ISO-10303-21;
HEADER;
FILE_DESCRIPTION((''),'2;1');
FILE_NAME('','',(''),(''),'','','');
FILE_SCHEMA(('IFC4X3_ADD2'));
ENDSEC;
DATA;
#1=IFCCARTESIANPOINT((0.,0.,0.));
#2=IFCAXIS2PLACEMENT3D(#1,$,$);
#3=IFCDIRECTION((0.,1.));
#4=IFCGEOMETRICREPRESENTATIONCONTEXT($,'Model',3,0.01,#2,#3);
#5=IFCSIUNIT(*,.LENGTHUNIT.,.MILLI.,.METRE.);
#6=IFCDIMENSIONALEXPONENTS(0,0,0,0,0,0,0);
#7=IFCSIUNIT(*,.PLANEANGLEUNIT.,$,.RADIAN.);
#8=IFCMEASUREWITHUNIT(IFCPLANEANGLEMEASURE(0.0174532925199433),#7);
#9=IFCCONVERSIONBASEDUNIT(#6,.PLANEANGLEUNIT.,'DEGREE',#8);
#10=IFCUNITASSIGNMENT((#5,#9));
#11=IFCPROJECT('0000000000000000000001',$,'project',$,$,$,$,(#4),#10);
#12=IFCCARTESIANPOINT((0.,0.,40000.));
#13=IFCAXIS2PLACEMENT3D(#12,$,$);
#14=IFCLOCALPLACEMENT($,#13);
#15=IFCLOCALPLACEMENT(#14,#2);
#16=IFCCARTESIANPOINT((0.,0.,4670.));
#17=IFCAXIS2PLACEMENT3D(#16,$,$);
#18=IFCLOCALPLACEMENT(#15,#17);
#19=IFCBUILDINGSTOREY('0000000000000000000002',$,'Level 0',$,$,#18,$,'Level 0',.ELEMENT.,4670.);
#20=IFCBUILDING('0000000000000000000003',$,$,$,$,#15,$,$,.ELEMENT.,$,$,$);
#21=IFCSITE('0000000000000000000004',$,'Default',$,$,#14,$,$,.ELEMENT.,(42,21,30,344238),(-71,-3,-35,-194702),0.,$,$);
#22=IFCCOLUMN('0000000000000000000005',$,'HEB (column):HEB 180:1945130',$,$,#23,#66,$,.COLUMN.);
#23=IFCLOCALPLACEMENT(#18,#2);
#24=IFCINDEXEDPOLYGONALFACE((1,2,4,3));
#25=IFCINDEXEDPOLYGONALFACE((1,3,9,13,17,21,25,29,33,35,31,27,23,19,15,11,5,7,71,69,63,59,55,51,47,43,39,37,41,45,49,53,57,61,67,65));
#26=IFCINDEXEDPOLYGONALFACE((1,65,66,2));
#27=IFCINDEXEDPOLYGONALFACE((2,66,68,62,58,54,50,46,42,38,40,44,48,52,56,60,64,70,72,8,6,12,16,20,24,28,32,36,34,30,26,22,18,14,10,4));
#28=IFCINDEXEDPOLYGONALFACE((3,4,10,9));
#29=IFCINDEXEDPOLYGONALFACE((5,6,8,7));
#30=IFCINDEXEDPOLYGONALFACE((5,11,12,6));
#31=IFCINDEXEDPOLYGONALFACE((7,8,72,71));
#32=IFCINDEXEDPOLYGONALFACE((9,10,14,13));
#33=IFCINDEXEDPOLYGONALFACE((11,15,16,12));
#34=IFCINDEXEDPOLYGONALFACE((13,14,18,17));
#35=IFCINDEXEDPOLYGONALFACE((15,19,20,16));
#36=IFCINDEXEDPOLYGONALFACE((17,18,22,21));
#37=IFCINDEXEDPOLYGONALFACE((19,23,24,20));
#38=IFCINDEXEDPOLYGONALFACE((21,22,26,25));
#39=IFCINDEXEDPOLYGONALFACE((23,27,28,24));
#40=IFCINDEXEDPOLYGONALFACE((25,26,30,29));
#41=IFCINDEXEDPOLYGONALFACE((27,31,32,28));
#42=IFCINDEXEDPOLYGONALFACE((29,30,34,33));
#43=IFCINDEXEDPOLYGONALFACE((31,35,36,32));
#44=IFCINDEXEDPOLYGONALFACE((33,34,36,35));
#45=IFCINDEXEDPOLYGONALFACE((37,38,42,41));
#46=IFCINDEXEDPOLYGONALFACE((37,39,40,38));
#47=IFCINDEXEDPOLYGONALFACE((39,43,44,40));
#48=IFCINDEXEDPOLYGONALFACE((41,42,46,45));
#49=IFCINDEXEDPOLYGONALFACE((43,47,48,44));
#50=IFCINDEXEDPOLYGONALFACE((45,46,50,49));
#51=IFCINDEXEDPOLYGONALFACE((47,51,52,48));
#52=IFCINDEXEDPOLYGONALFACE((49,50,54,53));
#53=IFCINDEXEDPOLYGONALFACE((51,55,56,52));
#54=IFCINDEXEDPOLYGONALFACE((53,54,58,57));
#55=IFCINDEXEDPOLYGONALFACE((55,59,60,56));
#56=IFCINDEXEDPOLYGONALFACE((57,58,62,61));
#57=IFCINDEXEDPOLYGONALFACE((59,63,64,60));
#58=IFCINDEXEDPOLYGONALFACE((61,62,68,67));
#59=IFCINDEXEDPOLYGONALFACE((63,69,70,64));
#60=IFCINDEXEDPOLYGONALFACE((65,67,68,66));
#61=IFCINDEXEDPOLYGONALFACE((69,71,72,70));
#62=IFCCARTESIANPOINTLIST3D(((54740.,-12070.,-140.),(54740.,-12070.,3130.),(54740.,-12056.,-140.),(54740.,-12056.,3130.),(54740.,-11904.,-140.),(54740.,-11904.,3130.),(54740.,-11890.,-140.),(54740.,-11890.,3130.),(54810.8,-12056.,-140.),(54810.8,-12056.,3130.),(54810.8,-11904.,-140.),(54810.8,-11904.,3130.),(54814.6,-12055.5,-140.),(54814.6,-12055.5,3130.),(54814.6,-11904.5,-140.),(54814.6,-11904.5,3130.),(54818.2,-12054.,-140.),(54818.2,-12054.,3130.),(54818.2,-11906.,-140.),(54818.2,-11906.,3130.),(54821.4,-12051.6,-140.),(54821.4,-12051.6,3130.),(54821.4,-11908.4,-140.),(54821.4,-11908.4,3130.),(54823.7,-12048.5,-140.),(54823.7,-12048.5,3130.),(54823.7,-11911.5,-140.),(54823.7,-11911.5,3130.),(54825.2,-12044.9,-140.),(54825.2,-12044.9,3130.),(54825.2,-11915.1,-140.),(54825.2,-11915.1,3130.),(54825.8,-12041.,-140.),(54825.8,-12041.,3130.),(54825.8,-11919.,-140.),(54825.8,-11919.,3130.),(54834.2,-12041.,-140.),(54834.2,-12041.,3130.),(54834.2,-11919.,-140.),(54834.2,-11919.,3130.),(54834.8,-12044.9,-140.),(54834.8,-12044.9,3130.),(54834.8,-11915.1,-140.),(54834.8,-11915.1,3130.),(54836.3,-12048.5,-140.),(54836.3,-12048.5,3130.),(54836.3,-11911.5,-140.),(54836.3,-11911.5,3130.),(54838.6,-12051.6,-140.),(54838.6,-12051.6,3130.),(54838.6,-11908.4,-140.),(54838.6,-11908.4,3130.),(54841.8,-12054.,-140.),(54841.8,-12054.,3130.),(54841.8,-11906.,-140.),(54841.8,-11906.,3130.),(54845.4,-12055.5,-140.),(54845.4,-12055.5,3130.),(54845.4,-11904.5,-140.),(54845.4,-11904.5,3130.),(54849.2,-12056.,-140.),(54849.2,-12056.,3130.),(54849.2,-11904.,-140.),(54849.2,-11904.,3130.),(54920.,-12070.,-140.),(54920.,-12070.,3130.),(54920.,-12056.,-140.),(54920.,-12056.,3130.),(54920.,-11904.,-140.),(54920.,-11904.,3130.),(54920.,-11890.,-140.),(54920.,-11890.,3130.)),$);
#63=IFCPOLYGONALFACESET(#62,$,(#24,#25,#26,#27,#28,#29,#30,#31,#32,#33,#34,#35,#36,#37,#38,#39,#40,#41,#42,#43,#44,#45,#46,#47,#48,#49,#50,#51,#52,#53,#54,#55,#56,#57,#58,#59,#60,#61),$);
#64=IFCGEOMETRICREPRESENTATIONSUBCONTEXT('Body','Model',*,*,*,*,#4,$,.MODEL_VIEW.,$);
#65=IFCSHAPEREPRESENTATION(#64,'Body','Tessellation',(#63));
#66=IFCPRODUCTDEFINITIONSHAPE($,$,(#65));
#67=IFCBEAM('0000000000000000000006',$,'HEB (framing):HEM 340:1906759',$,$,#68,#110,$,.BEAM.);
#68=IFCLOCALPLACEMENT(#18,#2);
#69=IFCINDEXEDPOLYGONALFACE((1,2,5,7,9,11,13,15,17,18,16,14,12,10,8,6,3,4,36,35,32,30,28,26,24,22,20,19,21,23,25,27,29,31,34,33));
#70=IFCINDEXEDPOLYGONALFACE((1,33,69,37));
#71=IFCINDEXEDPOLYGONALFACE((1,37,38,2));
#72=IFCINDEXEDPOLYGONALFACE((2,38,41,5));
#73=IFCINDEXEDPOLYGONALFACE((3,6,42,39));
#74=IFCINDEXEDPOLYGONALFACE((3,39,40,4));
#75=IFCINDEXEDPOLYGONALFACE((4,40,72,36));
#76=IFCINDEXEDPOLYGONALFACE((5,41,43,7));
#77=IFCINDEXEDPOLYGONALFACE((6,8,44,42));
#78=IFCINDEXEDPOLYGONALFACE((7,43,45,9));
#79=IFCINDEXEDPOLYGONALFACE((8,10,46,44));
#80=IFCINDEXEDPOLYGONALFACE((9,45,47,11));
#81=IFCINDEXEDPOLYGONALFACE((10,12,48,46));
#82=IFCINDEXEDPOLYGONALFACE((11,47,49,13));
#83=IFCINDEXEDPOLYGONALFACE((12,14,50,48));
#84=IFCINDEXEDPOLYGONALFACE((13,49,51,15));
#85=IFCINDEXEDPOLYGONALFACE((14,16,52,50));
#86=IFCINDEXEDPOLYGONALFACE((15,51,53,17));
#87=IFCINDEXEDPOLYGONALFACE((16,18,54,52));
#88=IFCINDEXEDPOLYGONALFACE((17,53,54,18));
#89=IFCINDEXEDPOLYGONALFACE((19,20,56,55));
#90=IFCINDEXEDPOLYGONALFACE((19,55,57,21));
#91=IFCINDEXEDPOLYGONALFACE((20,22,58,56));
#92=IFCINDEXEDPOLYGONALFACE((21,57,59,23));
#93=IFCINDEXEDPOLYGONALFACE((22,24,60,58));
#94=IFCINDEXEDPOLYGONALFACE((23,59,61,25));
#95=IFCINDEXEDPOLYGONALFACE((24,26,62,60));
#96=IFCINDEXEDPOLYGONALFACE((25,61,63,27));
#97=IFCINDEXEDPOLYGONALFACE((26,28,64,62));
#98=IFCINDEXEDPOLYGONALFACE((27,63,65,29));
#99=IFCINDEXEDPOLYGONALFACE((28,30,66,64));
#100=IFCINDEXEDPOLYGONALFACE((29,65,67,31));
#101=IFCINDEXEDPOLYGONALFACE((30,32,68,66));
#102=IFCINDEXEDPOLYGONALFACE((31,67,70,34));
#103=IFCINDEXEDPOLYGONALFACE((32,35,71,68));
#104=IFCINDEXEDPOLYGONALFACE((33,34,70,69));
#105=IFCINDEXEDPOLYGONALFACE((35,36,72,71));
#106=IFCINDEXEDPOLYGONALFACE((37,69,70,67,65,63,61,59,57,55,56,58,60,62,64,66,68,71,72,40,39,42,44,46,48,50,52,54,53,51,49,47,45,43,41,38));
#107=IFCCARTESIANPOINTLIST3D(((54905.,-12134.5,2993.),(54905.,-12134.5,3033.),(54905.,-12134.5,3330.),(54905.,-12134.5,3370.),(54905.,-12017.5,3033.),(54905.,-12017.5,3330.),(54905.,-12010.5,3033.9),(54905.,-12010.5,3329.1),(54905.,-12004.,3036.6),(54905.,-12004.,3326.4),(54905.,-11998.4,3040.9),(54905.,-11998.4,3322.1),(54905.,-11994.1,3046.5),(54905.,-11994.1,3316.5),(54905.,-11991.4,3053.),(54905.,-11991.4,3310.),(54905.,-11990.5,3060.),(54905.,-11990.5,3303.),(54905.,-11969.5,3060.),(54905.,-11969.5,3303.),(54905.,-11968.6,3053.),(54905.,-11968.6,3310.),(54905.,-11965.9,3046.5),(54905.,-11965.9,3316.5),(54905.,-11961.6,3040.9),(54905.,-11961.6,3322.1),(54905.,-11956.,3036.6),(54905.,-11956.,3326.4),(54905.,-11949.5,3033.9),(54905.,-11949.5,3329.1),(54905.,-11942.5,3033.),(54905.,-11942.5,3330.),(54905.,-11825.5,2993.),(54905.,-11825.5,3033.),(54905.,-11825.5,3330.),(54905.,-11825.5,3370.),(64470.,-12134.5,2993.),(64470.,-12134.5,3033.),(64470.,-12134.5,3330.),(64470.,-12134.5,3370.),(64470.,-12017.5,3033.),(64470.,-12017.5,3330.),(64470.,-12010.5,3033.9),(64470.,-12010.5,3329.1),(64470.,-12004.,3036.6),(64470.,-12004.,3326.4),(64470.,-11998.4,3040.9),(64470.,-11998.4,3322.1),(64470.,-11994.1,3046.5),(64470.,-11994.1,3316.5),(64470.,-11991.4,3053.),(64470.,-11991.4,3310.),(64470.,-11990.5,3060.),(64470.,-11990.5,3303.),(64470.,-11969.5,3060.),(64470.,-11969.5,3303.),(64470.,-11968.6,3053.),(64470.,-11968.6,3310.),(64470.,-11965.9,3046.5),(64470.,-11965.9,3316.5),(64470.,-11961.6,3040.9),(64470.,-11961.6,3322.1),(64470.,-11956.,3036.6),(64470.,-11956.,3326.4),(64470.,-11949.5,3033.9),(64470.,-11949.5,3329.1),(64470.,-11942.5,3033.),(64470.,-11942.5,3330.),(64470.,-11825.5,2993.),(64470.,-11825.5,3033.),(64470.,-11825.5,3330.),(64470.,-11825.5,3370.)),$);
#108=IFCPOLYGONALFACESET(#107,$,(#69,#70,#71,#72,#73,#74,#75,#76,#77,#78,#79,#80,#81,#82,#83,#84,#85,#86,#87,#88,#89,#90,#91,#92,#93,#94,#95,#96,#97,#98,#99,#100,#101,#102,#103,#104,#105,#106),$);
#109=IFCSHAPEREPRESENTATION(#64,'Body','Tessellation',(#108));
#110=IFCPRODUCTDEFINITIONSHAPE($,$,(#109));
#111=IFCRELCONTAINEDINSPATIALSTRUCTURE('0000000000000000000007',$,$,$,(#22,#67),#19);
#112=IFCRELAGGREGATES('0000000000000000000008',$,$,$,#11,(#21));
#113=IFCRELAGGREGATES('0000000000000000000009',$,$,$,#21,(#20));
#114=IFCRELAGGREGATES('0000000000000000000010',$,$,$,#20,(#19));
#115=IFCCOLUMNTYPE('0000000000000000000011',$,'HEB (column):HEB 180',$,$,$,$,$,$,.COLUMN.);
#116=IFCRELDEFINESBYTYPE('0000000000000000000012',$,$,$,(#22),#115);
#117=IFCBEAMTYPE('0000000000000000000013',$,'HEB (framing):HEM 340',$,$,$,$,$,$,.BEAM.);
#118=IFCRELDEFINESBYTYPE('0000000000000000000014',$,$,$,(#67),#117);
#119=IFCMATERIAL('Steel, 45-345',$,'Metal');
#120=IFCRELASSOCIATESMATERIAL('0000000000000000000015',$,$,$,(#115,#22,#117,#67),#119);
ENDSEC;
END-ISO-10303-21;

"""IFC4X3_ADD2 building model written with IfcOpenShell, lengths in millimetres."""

from ifc_helpers import new_model, entity, si_unit, converted_unit, direction, frame, frame_2d, origin, origin_2d_with_axis, place, context, subcontext, project, spatial, polyline, circle_curve, parameter, trimmed, segment, composite_curve, i_section, outline, extrude, source, transform, mapped, material, material_profile, profile_set, profile_usage, type_object, type_shapes, element, save


model = new_model("IFC4X3_ADD2")

# Units and contexts
model_context = context("Model", 3, precision=0.01, world=origin(), true_north=direction((0.0, 1.0)))
body_context = subcontext(model_context, "Body", "Model", "MODEL_VIEW")
ifc_project = project(units=[si_unit("LENGTHUNIT", "METRE", prefix="MILLI"), converted_unit("PLANEANGLEUNIT", "DEGREE", entity("IfcPlaneAngleMeasure", 0.0174532925199433), si_unit("PLANEANGLEUNIT", "RADIAN"), dimensions=[0, 0, 0, 0, 0, 0, 0])], contexts=[model_context])

# Site, building, storey
site_placement = place(None, frame((0.0, 0.0, 40000.0)))
site = spatial("IfcSite", under=ifc_project, at=site_placement, Name="Default", CompositionType="ELEMENT", RefLatitude=(42, 21, 30, 344238), RefLongitude=(-71, -3, -35, -194702), RefElevation=0.0)
building_placement = place(site_placement, origin())
building = spatial("IfcBuilding", under=site, at=building_placement, CompositionType="ELEMENT")
storey_placement = place(building_placement, frame((0.0, 0.0, 4670.0)))
storey = spatial("IfcBuildingStorey", under=building, at=storey_placement, Name="Level 0", LongName="Level 0", CompositionType="ELEMENT", Elevation=4670.0)

# Column
ifc_material_1 = material(Name="Steel, 45-345", Category="Metal")
ifc_material_profile_1 = material_profile(ifc_material_1, i_section(OverallWidth=180.0, OverallDepth=180.0, WebThickness=8.5, FlangeThickness=14.0, FilletRadius=15.0, at=origin_2d_with_axis()), Name="HEB 180")
ifc_profile_set_1 = profile_set([ifc_material_profile_1], Name="HEB 180")
ifc_profile_usage_1 = profile_usage(ifc_profile_set_1)
column_type = type_object("IfcColumnType", Name="HEB (column):HEB 180", PredefinedType="COLUMN", material=ifc_profile_set_1)
shared_shape_1 = source(origin(), body_context, "Body", "SweptSolid", [
    extrude(i_section(OverallWidth=180.0, OverallDepth=180.0, WebThickness=8.5, FlangeThickness=14.0, FilletRadius=15.0, at=origin_2d_with_axis()), frame((0.0, 0.0, 4530.0), z_axis=(0.0, 0.0, 1.0), x_axis=(-1.0, 0.0, 0.0)), (0.0, 0.0, 1.0), 3270.0),
])
type_shapes(column_type, [shared_shape_1])
for number, where, name in (
    (1, (54830.0, -11980.0, -4670.0), "HEB (column):HEB 180:1945130"),
):
    element("IfcColumn", number, at=place(storey_placement, frame(where)), inside=storey, type_object=column_type, material=ifc_profile_usage_1, Name=name, PredefinedType="COLUMN", context=body_context, shape_type="MappedRepresentation", body=[
        mapped(shared_shape_1, transform((0.0, 0.0, 0.0), scale=1.0)),
    ])

# Beam
ifc_material_profile_2 = material_profile(ifc_material_1, outline(composite_curve([segment(polyline([(-154.5, -148.5), (-154.5, -188.5)]), True, "CONTINUOUS"), segment(polyline([(-154.5, -188.5), (154.5, -188.5)]), True, "CONTINUOUS"), segment(polyline([(154.5, -188.5), (154.5, -148.5)]), True, "CONTINUOUS"), segment(polyline([(154.5, -148.5), (37.5, -148.5)]), True, "CONTINUOUS"), segment(trimmed(circle_curve(frame_2d((37.5, -121.5), x_axis=(1.0, 0.0)), 27.0), [parameter(180.0)], [parameter(270.0)], True, "PARAMETER"), False, "CONTINUOUS"), segment(polyline([(10.5, -121.5), (10.5, 121.5)]), True, "CONTINUOUS"), segment(trimmed(circle_curve(frame_2d((37.5, 121.5), x_axis=(1.0, 0.0)), 27.0), [parameter(90.0)], [parameter(180.0)], True, "PARAMETER"), False, "CONTINUOUS"), segment(polyline([(37.5, 148.5), (154.5, 148.5)]), True, "CONTINUOUS"), segment(polyline([(154.5, 148.5), (154.5, 188.5)]), True, "CONTINUOUS"), segment(polyline([(154.5, 188.5), (-154.5, 188.5)]), True, "CONTINUOUS"), segment(polyline([(-154.5, 188.5), (-154.5, 148.5)]), True, "CONTINUOUS"), segment(polyline([(-154.5, 148.5), (-37.5, 148.5)]), True, "CONTINUOUS"), segment(trimmed(circle_curve(frame_2d((-37.5, 121.5), x_axis=(1.0, 0.0)), 27.0), [parameter(360.0)], [parameter(90.0)], True, "PARAMETER"), False, "CONTINUOUS"), segment(polyline([(-10.5, 121.5), (-10.5, -121.5)]), True, "CONTINUOUS"), segment(trimmed(circle_curve(frame_2d((-37.5, -121.5), x_axis=(1.0, 0.0)), 27.0), [parameter(270.0)], [parameter(0.0)], True, "PARAMETER"), False, "CONTINUOUS"), segment(polyline([(-37.5, -148.5), (-154.5, -148.5)]), True, "CONTINUOUS")], self_intersect=False)), Name="HEM 340")
ifc_profile_set_2 = profile_set([ifc_material_profile_2], Name="HEM 340")
ifc_profile_usage_2 = profile_usage(ifc_profile_set_2, cardinal=8)
beam_type_1 = type_object("IfcBeamType", Name="HEB (framing):HEM 340", PredefinedType="BEAM", material=ifc_profile_set_2)
shared_shape_2 = source(origin(), body_context, "Body", "SweptSolid", [
    extrude(outline(composite_curve([segment(polyline([(-154.5, -148.5), (-154.5, -188.5)]), True, "CONTINUOUS"), segment(polyline([(-154.5, -188.5), (154.5, -188.5)]), True, "CONTINUOUS"), segment(polyline([(154.5, -188.5), (154.5, -148.5)]), True, "CONTINUOUS"), segment(polyline([(154.5, -148.5), (37.5, -148.5)]), True, "CONTINUOUS"), segment(trimmed(circle_curve(frame_2d((37.5, -121.5), x_axis=(1.0, 0.0)), 27.0), [parameter(180.0)], [parameter(270.0)], True, "PARAMETER"), False, "CONTINUOUS"), segment(polyline([(10.5, -121.5), (10.5, 121.5)]), True, "CONTINUOUS"), segment(trimmed(circle_curve(frame_2d((37.5, 121.5), x_axis=(1.0, 0.0)), 27.0), [parameter(90.0)], [parameter(180.0)], True, "PARAMETER"), False, "CONTINUOUS"), segment(polyline([(37.5, 148.5), (154.5, 148.5)]), True, "CONTINUOUS"), segment(polyline([(154.5, 148.5), (154.5, 188.5)]), True, "CONTINUOUS"), segment(polyline([(154.5, 188.5), (-154.5, 188.5)]), True, "CONTINUOUS"), segment(polyline([(-154.5, 188.5), (-154.5, 148.5)]), True, "CONTINUOUS"), segment(polyline([(-154.5, 148.5), (-37.5, 148.5)]), True, "CONTINUOUS"), segment(trimmed(circle_curve(frame_2d((-37.5, 121.5), x_axis=(1.0, 0.0)), 27.0), [parameter(360.0)], [parameter(90.0)], True, "PARAMETER"), False, "CONTINUOUS"), segment(polyline([(-10.5, 121.5), (-10.5, -121.5)]), True, "CONTINUOUS"), segment(trimmed(circle_curve(frame_2d((-37.5, -121.5), x_axis=(1.0, 0.0)), 27.0), [parameter(270.0)], [parameter(0.0)], True, "PARAMETER"), False, "CONTINUOUS"), segment(polyline([(-37.5, -148.5), (-154.5, -148.5)]), True, "CONTINUOUS")], self_intersect=False)), frame((-4794.0, 0.0, 0.0), z_axis=(-1.0, 0.0, 0.0), x_axis=(0.0, -1.0, 0.0)), (0.0, 0.0, -1.0), 9565.0),
])
type_shapes(beam_type_1, [shared_shape_2])
beam_1_placement = place(storey_placement, frame((59699.0, -11980.0, 3181.5)))
element("IfcBeam", 2, at=beam_1_placement, inside=storey, type_object=beam_type_1, material=ifc_profile_usage_2, Name="HEB (framing):HEM 340:1906759", PredefinedType="BEAM", context=body_context, shape_type="MappedRepresentation", body=[
    mapped(shared_shape_2, transform((0.0, 0.0, 0.0), scale=1.0)),
])

save(model, "model.ifc")
